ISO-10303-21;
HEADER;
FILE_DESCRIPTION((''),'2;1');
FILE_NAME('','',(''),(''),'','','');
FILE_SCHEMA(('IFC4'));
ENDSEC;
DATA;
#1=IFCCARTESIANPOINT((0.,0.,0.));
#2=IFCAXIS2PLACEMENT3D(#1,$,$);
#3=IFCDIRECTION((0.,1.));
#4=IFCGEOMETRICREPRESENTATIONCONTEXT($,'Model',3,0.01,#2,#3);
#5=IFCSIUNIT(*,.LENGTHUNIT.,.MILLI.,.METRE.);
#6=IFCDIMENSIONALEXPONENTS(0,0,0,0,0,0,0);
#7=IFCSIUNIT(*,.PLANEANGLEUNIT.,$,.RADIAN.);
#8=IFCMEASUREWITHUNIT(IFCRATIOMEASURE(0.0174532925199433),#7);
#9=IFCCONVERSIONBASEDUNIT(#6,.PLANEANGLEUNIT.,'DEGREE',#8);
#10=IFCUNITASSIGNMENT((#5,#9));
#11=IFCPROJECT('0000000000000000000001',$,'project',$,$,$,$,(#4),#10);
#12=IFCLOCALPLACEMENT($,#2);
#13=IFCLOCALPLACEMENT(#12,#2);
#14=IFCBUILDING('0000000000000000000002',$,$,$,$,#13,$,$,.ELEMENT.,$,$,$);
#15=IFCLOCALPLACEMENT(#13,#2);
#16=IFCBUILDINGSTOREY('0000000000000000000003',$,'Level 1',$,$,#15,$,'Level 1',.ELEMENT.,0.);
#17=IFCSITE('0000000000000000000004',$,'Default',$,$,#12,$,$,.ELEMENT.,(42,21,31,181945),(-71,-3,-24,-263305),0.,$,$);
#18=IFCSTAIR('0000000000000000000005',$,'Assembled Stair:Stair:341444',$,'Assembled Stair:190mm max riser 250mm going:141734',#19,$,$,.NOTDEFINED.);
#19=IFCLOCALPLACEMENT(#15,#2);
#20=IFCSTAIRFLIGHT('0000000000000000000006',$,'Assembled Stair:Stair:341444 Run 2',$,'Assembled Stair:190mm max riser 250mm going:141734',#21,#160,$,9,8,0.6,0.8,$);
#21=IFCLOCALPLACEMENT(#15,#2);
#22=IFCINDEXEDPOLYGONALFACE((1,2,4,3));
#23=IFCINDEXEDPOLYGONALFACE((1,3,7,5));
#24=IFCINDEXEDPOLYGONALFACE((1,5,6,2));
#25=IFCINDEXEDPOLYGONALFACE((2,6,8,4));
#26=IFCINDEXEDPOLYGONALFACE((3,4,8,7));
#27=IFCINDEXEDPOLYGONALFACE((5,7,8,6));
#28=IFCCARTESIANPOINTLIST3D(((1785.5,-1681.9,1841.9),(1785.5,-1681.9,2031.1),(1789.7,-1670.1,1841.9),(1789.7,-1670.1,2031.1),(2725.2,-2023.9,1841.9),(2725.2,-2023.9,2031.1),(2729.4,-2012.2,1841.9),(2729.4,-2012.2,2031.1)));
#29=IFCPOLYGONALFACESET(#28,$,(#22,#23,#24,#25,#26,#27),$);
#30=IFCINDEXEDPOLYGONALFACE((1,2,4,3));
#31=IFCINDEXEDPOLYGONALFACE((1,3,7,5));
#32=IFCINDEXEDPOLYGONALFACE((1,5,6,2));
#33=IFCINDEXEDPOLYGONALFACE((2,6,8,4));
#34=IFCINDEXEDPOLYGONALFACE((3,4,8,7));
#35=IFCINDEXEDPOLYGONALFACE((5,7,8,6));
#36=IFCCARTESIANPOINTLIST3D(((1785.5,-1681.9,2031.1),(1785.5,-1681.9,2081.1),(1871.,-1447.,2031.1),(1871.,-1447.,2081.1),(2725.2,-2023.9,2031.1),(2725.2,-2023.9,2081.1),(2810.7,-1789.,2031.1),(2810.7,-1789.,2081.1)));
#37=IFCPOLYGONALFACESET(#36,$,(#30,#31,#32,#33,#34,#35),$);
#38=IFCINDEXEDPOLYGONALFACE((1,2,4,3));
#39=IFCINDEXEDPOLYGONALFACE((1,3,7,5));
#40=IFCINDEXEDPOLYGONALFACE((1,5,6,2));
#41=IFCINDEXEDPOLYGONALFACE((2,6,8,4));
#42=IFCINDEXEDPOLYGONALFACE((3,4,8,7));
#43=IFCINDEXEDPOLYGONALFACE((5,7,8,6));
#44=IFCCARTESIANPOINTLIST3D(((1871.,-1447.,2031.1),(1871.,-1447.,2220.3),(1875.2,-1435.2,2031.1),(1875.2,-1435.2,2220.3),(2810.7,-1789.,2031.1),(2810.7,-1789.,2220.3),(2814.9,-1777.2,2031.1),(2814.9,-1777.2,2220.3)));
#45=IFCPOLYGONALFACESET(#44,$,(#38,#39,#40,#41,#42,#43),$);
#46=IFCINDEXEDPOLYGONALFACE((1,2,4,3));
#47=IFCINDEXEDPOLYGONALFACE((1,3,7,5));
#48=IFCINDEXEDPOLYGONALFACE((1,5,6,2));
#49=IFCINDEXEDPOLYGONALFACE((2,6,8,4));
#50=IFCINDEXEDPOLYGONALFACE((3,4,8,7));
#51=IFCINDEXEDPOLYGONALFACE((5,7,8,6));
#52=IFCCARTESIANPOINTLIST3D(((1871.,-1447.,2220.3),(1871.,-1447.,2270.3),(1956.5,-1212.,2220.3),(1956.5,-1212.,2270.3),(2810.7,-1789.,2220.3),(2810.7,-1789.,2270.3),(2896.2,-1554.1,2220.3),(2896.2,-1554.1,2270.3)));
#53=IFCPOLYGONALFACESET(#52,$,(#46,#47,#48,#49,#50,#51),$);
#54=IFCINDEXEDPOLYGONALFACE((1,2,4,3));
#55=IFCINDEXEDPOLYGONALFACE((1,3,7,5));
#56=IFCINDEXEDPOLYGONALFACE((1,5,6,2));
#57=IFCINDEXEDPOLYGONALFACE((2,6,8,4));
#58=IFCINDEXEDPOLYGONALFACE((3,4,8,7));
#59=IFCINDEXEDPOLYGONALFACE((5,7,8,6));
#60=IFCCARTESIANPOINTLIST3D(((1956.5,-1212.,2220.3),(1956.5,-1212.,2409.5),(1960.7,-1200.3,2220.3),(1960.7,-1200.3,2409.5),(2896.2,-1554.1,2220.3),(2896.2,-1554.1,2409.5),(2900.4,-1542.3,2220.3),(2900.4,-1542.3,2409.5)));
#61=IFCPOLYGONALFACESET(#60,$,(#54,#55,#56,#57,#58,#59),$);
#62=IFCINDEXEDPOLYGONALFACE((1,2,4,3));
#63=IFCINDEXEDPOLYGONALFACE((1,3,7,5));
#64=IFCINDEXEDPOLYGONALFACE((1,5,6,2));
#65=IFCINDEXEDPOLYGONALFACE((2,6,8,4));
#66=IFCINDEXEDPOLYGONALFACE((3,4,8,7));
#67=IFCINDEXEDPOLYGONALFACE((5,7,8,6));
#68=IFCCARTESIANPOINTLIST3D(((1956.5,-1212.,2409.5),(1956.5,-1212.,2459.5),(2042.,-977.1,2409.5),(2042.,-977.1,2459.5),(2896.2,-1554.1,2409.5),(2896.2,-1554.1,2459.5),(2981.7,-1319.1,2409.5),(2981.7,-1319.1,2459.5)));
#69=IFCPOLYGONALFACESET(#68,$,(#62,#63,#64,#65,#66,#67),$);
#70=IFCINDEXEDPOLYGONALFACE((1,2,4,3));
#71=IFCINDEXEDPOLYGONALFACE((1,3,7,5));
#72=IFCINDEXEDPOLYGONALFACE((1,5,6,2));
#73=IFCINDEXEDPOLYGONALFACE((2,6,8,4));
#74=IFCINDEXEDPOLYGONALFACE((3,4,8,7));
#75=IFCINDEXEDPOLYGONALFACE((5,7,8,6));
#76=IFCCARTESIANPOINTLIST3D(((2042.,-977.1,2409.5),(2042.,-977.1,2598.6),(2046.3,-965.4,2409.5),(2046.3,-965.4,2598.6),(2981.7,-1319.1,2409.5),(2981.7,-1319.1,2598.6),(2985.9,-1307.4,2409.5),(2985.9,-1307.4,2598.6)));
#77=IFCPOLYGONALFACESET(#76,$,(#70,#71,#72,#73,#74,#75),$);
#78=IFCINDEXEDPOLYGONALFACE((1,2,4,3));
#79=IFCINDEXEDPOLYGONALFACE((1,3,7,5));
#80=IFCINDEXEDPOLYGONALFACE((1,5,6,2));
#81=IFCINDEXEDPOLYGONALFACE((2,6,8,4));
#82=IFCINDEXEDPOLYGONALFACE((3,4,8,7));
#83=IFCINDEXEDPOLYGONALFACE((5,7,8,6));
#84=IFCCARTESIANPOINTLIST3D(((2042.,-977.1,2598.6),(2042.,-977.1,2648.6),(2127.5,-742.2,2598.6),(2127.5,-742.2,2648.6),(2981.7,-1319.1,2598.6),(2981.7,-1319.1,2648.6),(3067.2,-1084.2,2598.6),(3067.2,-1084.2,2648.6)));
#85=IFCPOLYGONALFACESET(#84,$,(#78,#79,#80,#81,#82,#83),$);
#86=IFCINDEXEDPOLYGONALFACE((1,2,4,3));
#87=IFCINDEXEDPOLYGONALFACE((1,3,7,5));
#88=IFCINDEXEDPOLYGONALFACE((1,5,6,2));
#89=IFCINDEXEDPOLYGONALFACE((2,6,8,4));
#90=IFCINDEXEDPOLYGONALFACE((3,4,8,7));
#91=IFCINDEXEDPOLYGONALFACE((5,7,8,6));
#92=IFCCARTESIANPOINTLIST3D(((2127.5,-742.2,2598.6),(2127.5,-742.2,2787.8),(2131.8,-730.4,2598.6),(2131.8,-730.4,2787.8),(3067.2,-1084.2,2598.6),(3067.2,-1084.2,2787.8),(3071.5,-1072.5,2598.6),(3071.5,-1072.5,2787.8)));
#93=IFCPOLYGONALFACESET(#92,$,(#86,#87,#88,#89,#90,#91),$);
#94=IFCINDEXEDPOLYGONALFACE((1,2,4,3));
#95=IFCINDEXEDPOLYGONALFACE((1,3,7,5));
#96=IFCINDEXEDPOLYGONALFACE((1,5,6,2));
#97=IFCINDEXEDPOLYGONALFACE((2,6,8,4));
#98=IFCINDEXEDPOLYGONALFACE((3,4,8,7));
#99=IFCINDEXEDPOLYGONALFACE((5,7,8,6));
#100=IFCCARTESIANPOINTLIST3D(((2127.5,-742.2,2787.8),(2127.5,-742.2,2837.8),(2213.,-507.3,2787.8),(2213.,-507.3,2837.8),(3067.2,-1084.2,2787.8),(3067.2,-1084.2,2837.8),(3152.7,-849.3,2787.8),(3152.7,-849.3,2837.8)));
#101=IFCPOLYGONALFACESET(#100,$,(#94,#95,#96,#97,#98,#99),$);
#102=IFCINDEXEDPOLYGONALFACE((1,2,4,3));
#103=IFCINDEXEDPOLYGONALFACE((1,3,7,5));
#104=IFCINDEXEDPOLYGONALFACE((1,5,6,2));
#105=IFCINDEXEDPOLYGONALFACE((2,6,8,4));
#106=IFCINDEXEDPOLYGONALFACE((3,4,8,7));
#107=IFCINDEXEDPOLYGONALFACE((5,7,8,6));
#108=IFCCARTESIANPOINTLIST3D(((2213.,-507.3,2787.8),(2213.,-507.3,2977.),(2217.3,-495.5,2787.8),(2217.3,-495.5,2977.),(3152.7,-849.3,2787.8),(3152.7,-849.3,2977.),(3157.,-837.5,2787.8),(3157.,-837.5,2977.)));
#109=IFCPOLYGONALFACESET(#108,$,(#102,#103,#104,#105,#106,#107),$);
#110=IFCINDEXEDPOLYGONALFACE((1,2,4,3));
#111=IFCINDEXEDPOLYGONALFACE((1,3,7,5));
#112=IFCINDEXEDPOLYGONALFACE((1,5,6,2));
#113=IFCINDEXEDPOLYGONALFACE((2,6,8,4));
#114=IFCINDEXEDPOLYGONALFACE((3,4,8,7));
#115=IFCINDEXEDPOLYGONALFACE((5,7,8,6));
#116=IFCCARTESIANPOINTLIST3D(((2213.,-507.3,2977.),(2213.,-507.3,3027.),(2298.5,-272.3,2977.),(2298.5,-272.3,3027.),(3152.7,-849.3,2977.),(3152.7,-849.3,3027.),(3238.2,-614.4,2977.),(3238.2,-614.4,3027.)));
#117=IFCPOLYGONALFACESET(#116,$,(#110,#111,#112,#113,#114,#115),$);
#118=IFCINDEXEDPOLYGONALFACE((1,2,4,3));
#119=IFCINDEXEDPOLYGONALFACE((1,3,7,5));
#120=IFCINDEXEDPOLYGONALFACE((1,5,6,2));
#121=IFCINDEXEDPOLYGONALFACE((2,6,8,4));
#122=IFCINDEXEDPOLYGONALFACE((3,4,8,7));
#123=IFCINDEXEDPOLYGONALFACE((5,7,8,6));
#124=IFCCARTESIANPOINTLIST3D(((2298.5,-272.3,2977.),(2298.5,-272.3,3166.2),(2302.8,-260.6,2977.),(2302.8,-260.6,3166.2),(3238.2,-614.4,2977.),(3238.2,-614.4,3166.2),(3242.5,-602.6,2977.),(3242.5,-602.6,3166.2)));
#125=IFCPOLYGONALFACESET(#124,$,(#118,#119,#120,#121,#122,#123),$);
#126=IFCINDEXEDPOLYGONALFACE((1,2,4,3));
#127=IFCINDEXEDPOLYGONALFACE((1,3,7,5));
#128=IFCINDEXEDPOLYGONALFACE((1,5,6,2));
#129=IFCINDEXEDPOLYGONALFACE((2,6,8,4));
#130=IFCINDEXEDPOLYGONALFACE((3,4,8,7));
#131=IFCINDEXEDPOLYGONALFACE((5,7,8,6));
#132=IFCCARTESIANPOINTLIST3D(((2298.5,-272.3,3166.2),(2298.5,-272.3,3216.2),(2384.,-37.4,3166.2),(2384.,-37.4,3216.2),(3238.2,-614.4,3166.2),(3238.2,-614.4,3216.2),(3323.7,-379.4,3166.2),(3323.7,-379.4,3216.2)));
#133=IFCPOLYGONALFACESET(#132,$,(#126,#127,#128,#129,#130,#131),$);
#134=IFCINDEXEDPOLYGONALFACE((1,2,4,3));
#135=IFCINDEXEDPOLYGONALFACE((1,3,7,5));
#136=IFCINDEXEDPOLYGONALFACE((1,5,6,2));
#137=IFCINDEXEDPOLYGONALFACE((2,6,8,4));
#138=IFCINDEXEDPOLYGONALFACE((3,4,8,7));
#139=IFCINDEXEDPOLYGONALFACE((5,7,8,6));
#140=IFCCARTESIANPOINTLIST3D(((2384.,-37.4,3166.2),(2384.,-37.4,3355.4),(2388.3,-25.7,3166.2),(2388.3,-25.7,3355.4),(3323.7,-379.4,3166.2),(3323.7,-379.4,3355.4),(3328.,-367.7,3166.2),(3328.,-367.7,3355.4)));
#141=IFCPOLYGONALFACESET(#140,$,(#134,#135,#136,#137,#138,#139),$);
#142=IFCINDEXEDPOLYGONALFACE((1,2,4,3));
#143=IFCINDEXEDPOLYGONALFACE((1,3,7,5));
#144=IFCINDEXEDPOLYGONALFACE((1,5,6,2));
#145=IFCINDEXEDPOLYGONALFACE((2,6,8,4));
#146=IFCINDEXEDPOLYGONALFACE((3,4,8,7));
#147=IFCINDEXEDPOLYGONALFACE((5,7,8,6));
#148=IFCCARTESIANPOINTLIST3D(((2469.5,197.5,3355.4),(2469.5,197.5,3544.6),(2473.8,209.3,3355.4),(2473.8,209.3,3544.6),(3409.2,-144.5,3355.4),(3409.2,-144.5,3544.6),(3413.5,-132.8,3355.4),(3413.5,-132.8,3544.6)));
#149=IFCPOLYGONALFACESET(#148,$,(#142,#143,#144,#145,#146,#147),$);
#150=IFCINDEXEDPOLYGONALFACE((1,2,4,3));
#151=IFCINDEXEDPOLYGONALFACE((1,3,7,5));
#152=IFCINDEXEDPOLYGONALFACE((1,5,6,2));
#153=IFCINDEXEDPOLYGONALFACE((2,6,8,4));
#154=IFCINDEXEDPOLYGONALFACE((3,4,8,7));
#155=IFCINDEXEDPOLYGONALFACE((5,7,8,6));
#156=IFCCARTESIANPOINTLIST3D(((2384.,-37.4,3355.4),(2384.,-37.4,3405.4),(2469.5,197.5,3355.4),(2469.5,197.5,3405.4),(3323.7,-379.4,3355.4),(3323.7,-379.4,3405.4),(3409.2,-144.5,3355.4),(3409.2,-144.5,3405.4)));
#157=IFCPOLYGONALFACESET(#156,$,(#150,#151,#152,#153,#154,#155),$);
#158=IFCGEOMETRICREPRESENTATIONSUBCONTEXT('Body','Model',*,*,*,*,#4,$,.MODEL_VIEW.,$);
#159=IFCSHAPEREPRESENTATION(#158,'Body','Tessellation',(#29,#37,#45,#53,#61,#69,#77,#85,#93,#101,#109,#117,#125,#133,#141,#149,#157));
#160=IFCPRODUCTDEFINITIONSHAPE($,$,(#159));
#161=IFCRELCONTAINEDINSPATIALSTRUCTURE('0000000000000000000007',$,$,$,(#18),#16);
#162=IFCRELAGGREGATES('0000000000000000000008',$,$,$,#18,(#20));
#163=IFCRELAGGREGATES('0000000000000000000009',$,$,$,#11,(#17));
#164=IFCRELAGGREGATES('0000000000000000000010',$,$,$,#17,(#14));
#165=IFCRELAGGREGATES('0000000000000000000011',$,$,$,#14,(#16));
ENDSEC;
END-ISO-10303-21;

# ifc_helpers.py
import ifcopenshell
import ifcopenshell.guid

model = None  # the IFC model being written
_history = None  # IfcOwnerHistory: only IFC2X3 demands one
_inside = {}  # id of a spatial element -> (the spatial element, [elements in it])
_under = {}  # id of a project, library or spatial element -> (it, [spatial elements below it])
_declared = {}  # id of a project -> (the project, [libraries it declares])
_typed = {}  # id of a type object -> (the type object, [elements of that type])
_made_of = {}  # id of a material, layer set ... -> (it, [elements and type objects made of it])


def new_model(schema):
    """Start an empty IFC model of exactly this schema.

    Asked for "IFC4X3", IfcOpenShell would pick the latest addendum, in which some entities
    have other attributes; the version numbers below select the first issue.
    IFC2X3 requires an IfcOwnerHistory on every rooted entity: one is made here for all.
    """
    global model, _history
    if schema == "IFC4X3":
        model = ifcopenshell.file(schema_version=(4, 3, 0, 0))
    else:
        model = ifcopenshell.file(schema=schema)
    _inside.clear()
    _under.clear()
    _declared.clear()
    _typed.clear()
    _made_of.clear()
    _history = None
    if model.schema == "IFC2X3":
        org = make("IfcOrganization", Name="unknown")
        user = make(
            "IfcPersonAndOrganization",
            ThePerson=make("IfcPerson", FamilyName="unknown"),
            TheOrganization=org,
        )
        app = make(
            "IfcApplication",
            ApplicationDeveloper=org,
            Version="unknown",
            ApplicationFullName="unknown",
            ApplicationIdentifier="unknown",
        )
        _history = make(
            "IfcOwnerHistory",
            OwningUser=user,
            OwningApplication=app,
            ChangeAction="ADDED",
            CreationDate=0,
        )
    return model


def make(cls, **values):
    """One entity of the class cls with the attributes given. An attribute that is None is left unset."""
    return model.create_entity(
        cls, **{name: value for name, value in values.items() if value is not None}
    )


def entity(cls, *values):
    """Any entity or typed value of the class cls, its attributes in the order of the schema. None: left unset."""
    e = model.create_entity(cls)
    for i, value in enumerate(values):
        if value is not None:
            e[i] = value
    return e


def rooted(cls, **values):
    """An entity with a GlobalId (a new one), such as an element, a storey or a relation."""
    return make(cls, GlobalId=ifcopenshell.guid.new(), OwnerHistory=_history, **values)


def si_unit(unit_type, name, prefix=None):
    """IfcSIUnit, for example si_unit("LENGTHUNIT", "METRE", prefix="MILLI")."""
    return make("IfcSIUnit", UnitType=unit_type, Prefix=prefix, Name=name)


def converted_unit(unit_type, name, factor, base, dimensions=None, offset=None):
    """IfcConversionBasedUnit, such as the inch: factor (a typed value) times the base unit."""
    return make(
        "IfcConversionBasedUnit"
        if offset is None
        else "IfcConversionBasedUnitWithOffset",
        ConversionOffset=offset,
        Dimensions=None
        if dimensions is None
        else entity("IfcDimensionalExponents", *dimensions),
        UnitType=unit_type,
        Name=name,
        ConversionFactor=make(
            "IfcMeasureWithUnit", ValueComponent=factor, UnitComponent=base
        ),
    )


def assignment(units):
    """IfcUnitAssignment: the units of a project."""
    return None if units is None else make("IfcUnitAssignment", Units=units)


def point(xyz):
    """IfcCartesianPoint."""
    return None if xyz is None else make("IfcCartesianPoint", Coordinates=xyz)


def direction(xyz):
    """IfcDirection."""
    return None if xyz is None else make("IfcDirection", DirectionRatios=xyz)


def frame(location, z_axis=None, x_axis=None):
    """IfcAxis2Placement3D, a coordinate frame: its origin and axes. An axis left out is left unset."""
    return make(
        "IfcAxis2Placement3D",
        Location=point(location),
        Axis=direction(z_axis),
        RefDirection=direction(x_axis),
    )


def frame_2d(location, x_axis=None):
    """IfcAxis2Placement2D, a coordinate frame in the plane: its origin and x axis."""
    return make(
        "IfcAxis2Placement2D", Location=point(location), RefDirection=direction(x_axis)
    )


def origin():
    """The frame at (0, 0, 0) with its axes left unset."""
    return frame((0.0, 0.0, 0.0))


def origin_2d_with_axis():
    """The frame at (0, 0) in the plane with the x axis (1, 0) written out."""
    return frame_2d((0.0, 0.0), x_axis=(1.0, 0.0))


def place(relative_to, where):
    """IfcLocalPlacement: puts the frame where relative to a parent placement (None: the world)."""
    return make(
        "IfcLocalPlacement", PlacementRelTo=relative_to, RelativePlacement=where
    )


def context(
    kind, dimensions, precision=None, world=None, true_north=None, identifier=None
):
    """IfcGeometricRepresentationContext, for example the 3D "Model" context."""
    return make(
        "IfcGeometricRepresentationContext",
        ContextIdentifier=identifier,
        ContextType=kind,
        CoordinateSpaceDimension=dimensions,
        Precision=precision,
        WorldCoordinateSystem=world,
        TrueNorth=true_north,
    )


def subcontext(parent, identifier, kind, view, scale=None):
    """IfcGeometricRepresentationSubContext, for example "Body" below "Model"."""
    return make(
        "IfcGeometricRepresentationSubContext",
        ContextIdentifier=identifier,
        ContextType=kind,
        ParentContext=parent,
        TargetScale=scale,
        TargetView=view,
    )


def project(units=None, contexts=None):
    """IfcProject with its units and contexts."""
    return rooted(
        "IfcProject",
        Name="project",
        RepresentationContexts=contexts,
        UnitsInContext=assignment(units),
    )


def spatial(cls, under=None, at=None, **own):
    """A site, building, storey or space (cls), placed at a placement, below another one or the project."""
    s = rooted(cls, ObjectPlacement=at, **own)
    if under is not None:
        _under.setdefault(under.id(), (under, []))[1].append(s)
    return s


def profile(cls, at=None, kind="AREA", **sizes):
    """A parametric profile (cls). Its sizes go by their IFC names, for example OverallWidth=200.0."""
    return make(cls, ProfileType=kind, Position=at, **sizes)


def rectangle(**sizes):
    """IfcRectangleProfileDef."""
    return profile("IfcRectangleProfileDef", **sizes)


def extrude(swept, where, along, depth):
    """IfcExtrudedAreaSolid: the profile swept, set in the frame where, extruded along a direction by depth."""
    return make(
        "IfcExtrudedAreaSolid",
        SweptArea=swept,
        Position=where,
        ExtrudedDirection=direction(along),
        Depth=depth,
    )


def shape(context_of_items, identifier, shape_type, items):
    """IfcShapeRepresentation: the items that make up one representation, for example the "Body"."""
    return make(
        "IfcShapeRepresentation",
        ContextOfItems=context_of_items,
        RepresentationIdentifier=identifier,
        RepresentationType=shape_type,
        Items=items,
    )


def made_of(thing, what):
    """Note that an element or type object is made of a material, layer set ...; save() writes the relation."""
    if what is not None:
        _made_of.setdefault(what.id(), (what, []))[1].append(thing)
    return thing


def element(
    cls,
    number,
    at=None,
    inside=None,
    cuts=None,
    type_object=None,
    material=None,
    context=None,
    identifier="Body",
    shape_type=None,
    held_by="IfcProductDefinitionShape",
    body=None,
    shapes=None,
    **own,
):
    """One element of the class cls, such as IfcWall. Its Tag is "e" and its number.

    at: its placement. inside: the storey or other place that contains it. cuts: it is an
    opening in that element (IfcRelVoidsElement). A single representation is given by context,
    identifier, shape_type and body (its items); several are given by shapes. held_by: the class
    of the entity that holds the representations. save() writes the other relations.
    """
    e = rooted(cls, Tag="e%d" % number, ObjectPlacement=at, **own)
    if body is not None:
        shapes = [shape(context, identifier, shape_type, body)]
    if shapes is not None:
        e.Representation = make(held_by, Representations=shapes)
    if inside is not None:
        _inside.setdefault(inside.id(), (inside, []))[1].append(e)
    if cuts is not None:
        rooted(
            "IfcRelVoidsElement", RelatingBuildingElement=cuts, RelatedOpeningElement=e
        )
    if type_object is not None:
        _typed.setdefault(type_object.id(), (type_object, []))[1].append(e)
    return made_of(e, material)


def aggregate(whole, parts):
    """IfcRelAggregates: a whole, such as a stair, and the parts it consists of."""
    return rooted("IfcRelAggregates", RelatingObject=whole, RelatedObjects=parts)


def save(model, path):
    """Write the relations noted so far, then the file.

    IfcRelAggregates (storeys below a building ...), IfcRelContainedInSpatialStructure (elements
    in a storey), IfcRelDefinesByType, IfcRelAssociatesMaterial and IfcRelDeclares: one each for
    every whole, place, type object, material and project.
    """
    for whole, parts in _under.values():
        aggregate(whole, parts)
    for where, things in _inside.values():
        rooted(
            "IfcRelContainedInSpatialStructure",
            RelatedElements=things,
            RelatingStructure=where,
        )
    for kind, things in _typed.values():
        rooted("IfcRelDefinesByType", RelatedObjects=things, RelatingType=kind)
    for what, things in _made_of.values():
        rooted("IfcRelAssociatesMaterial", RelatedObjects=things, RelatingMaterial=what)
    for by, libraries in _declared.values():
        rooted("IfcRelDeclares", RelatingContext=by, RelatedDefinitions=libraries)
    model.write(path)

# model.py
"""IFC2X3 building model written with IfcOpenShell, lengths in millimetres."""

from ifc_helpers import new_model, entity, si_unit, converted_unit, direction, frame, frame_2d, origin, origin_2d_with_axis, place, context, subcontext, project, spatial, rectangle, extrude, element, aggregate, save


model = new_model("IFC2X3")

# Units and contexts
model_context = context("Model", 3, precision=0.01, world=origin(), true_north=direction((0.0, 1.0)))
body_context = subcontext(model_context, "Body", "Model", "MODEL_VIEW")
ifc_project = project(units=[si_unit("LENGTHUNIT", "METRE", prefix="MILLI"), converted_unit("PLANEANGLEUNIT", "DEGREE", entity("IfcRatioMeasure", 0.0174532925199433), si_unit("PLANEANGLEUNIT", "RADIAN"), dimensions=[0, 0, 0, 0, 0, 0, 0])], contexts=[model_context])

# Site, building, storey
site_placement = place(None, origin())
site = spatial("IfcSite", under=ifc_project, at=site_placement, Name="Default", CompositionType="ELEMENT", RefLatitude=(42, 21, 31, 181945), RefLongitude=(-71, -3, -24, -263305), RefElevation=0.0)
building_placement = place(site_placement, origin())
building = spatial("IfcBuilding", under=site, at=building_placement, CompositionType="ELEMENT")
storey_placement = place(building_placement, origin())
storey = spatial("IfcBuildingStorey", under=building, at=storey_placement, Name="Level 1", LongName="Level 1", CompositionType="ELEMENT", Elevation=0.0)

# Stair
stair_placement = place(storey_placement, origin())
stair = element("IfcStair", 1, at=stair_placement, inside=storey, Name="Assembled Stair:Stair:341444", ObjectType="Assembled Stair:190mm max riser 250mm going:141734", ShapeType="NOTDEFINED")

# Stair flight
stair_flight_1_placement = place(stair_placement, origin())
stair_flight_1 = element("IfcStairFlight", 2, at=stair_flight_1_placement, Name="Assembled Stair:Stair:341444 Run 2", ObjectType="Assembled Stair:190mm max riser 250mm going:141734", NumberOfRiser=9, NumberOfTreads=8, RiserHeight=0.6, TreadLength=0.8, context=body_context, shape_type="SweptSolid", body=[
    extrude(rectangle(XDim=1000.0, YDim=12.5, at=origin_2d_with_axis()), frame((2257.4, -1847.0, 1841.9), z_axis=(0.0, 0.0, 1.0), x_axis=(-0.939693, 0.34202, 0.0)), (0.0, 0.0, 1.0), 189.2),
    extrude(rectangle(XDim=250.0, YDim=1000.0, at=frame_2d((0.0, 0.0), x_axis=(1.0, 0.0))), frame((2298.1, -1735.4, 2031.1), z_axis=(0.0, 0.0, 1.0), x_axis=(-0.34202, -0.939693, 0.0)), (0.0, 0.0, 1.0), 50.0),
    extrude(rectangle(XDim=1000.0, YDim=12.5, at=origin_2d_with_axis()), frame((2343.0, -1612.1, 2031.1), z_axis=(0.0, 0.0, 1.0), x_axis=(-0.939693, 0.34202, 0.0)), (0.0, 0.0, 1.0), 189.2),
    extrude(rectangle(XDim=250.0, YDim=1000.0, at=frame_2d((0.0, 0.0), x_axis=(1.0, 0.0))), frame((2383.6, -1500.5, 2220.3), z_axis=(0.0, 0.0, 1.0), x_axis=(-0.34202, -0.939693, 0.0)), (0.0, 0.0, 1.0), 50.0),
    extrude(rectangle(XDim=1000.0, YDim=12.5, at=origin_2d_with_axis()), frame((2428.5, -1377.2, 2220.3), z_axis=(0.0, 0.0, 1.0), x_axis=(-0.939693, 0.34202, 0.0)), (0.0, 0.0, 1.0), 189.2),
    extrude(rectangle(XDim=250.0, YDim=1000.0, at=frame_2d((0.0, 0.0), x_axis=(1.0, 0.0))), frame((2469.1, -1265.6, 2409.5), z_axis=(0.0, 0.0, 1.0), x_axis=(-0.34202, -0.939693, 0.0)), (0.0, 0.0, 1.0), 50.0),
    extrude(rectangle(XDim=1000.0, YDim=12.5, at=origin_2d_with_axis()), frame((2514.0, -1142.2, 2409.5), z_axis=(0.0, 0.0, 1.0), x_axis=(-0.939693, 0.34202, 0.0)), (0.0, 0.0, 1.0), 189.2),
    extrude(rectangle(XDim=250.0, YDim=1000.0, at=frame_2d((0.0, 0.0), x_axis=(1.0, 0.0))), frame((2554.6, -1030.7, 2598.6), z_axis=(0.0, 0.0, 1.0), x_axis=(-0.34202, -0.939693, 0.0)), (0.0, 0.0, 1.0), 50.0),
    extrude(rectangle(XDim=1000.0, YDim=12.5, at=origin_2d_with_axis()), frame((2599.5, -907.3, 2598.6), z_axis=(0.0, 0.0, 1.0), x_axis=(-0.939693, 0.34202, 0.0)), (0.0, 0.0, 1.0), 189.2),
    extrude(rectangle(XDim=250.0, YDim=1000.0, at=frame_2d((0.0, 0.0), x_axis=(1.0, 0.0))), frame((2640.1, -795.7, 2787.8), z_axis=(0.0, 0.0, 1.0), x_axis=(-0.34202, -0.939693, 0.0)), (0.0, 0.0, 1.0), 50.0),
    extrude(rectangle(XDim=1000.0, YDim=12.5, at=origin_2d_with_axis()), frame((2685.0, -672.4, 2787.8), z_axis=(0.0, 0.0, 1.0), x_axis=(-0.939693, 0.34202, 0.0)), (0.0, 0.0, 1.0), 189.2),
    extrude(rectangle(XDim=250.0, YDim=1000.0, at=frame_2d((0.0, 0.0), x_axis=(1.0, 0.0))), frame((2725.6, -560.8, 2977.0), z_axis=(0.0, 0.0, 1.0), x_axis=(-0.34202, -0.939693, 0.0)), (0.0, 0.0, 1.0), 50.0),
    extrude(rectangle(XDim=1000.0, YDim=12.5, at=frame_2d((0.0, 0.0), x_axis=(1.0, 0.0))), frame((2770.5, -437.5, 2977.0), z_axis=(0.0, 0.0, 1.0), x_axis=(-0.939693, 0.34202, 0.0)), (0.0, 0.0, 1.0), 189.2),
    extrude(rectangle(XDim=250.0, YDim=1000.0, at=frame_2d((0.0, 0.0), x_axis=(1.0, 0.0))), frame((2811.1, -325.9, 3166.2), z_axis=(0.0, 0.0, 1.0), x_axis=(-0.34202, -0.939693, 0.0)), (0.0, 0.0, 1.0), 50.0),
    extrude(rectangle(XDim=1000.0, YDim=12.5, at=frame_2d((0.0, 0.0), x_axis=(1.0, 0.0))), frame((2856.0, -202.6, 3166.2), z_axis=(0.0, 0.0, 1.0), x_axis=(-0.939693, 0.34202, 0.0)), (0.0, 0.0, 1.0), 189.2),
    extrude(rectangle(XDim=1000.0, YDim=12.5, at=origin_2d_with_axis()), frame((2941.5, 32.4, 3355.4), z_axis=(0.0, 0.0, 1.0), x_axis=(-0.939693, 0.34202, 0.0)), (0.0, 0.0, 1.0), 189.2),
    extrude(rectangle(XDim=250.0, YDim=1000.0, at=frame_2d((0.0, 0.0), x_axis=(1.0, 0.0))), frame((2896.6, -91.0, 3355.4), z_axis=(0.0, 0.0, 1.0), x_axis=(-0.34202, -0.939693, 0.0)), (0.0, 0.0, 1.0), 50.0),
])
aggregate(stair, [stair_flight_1])

save(model, "model.ifc")
